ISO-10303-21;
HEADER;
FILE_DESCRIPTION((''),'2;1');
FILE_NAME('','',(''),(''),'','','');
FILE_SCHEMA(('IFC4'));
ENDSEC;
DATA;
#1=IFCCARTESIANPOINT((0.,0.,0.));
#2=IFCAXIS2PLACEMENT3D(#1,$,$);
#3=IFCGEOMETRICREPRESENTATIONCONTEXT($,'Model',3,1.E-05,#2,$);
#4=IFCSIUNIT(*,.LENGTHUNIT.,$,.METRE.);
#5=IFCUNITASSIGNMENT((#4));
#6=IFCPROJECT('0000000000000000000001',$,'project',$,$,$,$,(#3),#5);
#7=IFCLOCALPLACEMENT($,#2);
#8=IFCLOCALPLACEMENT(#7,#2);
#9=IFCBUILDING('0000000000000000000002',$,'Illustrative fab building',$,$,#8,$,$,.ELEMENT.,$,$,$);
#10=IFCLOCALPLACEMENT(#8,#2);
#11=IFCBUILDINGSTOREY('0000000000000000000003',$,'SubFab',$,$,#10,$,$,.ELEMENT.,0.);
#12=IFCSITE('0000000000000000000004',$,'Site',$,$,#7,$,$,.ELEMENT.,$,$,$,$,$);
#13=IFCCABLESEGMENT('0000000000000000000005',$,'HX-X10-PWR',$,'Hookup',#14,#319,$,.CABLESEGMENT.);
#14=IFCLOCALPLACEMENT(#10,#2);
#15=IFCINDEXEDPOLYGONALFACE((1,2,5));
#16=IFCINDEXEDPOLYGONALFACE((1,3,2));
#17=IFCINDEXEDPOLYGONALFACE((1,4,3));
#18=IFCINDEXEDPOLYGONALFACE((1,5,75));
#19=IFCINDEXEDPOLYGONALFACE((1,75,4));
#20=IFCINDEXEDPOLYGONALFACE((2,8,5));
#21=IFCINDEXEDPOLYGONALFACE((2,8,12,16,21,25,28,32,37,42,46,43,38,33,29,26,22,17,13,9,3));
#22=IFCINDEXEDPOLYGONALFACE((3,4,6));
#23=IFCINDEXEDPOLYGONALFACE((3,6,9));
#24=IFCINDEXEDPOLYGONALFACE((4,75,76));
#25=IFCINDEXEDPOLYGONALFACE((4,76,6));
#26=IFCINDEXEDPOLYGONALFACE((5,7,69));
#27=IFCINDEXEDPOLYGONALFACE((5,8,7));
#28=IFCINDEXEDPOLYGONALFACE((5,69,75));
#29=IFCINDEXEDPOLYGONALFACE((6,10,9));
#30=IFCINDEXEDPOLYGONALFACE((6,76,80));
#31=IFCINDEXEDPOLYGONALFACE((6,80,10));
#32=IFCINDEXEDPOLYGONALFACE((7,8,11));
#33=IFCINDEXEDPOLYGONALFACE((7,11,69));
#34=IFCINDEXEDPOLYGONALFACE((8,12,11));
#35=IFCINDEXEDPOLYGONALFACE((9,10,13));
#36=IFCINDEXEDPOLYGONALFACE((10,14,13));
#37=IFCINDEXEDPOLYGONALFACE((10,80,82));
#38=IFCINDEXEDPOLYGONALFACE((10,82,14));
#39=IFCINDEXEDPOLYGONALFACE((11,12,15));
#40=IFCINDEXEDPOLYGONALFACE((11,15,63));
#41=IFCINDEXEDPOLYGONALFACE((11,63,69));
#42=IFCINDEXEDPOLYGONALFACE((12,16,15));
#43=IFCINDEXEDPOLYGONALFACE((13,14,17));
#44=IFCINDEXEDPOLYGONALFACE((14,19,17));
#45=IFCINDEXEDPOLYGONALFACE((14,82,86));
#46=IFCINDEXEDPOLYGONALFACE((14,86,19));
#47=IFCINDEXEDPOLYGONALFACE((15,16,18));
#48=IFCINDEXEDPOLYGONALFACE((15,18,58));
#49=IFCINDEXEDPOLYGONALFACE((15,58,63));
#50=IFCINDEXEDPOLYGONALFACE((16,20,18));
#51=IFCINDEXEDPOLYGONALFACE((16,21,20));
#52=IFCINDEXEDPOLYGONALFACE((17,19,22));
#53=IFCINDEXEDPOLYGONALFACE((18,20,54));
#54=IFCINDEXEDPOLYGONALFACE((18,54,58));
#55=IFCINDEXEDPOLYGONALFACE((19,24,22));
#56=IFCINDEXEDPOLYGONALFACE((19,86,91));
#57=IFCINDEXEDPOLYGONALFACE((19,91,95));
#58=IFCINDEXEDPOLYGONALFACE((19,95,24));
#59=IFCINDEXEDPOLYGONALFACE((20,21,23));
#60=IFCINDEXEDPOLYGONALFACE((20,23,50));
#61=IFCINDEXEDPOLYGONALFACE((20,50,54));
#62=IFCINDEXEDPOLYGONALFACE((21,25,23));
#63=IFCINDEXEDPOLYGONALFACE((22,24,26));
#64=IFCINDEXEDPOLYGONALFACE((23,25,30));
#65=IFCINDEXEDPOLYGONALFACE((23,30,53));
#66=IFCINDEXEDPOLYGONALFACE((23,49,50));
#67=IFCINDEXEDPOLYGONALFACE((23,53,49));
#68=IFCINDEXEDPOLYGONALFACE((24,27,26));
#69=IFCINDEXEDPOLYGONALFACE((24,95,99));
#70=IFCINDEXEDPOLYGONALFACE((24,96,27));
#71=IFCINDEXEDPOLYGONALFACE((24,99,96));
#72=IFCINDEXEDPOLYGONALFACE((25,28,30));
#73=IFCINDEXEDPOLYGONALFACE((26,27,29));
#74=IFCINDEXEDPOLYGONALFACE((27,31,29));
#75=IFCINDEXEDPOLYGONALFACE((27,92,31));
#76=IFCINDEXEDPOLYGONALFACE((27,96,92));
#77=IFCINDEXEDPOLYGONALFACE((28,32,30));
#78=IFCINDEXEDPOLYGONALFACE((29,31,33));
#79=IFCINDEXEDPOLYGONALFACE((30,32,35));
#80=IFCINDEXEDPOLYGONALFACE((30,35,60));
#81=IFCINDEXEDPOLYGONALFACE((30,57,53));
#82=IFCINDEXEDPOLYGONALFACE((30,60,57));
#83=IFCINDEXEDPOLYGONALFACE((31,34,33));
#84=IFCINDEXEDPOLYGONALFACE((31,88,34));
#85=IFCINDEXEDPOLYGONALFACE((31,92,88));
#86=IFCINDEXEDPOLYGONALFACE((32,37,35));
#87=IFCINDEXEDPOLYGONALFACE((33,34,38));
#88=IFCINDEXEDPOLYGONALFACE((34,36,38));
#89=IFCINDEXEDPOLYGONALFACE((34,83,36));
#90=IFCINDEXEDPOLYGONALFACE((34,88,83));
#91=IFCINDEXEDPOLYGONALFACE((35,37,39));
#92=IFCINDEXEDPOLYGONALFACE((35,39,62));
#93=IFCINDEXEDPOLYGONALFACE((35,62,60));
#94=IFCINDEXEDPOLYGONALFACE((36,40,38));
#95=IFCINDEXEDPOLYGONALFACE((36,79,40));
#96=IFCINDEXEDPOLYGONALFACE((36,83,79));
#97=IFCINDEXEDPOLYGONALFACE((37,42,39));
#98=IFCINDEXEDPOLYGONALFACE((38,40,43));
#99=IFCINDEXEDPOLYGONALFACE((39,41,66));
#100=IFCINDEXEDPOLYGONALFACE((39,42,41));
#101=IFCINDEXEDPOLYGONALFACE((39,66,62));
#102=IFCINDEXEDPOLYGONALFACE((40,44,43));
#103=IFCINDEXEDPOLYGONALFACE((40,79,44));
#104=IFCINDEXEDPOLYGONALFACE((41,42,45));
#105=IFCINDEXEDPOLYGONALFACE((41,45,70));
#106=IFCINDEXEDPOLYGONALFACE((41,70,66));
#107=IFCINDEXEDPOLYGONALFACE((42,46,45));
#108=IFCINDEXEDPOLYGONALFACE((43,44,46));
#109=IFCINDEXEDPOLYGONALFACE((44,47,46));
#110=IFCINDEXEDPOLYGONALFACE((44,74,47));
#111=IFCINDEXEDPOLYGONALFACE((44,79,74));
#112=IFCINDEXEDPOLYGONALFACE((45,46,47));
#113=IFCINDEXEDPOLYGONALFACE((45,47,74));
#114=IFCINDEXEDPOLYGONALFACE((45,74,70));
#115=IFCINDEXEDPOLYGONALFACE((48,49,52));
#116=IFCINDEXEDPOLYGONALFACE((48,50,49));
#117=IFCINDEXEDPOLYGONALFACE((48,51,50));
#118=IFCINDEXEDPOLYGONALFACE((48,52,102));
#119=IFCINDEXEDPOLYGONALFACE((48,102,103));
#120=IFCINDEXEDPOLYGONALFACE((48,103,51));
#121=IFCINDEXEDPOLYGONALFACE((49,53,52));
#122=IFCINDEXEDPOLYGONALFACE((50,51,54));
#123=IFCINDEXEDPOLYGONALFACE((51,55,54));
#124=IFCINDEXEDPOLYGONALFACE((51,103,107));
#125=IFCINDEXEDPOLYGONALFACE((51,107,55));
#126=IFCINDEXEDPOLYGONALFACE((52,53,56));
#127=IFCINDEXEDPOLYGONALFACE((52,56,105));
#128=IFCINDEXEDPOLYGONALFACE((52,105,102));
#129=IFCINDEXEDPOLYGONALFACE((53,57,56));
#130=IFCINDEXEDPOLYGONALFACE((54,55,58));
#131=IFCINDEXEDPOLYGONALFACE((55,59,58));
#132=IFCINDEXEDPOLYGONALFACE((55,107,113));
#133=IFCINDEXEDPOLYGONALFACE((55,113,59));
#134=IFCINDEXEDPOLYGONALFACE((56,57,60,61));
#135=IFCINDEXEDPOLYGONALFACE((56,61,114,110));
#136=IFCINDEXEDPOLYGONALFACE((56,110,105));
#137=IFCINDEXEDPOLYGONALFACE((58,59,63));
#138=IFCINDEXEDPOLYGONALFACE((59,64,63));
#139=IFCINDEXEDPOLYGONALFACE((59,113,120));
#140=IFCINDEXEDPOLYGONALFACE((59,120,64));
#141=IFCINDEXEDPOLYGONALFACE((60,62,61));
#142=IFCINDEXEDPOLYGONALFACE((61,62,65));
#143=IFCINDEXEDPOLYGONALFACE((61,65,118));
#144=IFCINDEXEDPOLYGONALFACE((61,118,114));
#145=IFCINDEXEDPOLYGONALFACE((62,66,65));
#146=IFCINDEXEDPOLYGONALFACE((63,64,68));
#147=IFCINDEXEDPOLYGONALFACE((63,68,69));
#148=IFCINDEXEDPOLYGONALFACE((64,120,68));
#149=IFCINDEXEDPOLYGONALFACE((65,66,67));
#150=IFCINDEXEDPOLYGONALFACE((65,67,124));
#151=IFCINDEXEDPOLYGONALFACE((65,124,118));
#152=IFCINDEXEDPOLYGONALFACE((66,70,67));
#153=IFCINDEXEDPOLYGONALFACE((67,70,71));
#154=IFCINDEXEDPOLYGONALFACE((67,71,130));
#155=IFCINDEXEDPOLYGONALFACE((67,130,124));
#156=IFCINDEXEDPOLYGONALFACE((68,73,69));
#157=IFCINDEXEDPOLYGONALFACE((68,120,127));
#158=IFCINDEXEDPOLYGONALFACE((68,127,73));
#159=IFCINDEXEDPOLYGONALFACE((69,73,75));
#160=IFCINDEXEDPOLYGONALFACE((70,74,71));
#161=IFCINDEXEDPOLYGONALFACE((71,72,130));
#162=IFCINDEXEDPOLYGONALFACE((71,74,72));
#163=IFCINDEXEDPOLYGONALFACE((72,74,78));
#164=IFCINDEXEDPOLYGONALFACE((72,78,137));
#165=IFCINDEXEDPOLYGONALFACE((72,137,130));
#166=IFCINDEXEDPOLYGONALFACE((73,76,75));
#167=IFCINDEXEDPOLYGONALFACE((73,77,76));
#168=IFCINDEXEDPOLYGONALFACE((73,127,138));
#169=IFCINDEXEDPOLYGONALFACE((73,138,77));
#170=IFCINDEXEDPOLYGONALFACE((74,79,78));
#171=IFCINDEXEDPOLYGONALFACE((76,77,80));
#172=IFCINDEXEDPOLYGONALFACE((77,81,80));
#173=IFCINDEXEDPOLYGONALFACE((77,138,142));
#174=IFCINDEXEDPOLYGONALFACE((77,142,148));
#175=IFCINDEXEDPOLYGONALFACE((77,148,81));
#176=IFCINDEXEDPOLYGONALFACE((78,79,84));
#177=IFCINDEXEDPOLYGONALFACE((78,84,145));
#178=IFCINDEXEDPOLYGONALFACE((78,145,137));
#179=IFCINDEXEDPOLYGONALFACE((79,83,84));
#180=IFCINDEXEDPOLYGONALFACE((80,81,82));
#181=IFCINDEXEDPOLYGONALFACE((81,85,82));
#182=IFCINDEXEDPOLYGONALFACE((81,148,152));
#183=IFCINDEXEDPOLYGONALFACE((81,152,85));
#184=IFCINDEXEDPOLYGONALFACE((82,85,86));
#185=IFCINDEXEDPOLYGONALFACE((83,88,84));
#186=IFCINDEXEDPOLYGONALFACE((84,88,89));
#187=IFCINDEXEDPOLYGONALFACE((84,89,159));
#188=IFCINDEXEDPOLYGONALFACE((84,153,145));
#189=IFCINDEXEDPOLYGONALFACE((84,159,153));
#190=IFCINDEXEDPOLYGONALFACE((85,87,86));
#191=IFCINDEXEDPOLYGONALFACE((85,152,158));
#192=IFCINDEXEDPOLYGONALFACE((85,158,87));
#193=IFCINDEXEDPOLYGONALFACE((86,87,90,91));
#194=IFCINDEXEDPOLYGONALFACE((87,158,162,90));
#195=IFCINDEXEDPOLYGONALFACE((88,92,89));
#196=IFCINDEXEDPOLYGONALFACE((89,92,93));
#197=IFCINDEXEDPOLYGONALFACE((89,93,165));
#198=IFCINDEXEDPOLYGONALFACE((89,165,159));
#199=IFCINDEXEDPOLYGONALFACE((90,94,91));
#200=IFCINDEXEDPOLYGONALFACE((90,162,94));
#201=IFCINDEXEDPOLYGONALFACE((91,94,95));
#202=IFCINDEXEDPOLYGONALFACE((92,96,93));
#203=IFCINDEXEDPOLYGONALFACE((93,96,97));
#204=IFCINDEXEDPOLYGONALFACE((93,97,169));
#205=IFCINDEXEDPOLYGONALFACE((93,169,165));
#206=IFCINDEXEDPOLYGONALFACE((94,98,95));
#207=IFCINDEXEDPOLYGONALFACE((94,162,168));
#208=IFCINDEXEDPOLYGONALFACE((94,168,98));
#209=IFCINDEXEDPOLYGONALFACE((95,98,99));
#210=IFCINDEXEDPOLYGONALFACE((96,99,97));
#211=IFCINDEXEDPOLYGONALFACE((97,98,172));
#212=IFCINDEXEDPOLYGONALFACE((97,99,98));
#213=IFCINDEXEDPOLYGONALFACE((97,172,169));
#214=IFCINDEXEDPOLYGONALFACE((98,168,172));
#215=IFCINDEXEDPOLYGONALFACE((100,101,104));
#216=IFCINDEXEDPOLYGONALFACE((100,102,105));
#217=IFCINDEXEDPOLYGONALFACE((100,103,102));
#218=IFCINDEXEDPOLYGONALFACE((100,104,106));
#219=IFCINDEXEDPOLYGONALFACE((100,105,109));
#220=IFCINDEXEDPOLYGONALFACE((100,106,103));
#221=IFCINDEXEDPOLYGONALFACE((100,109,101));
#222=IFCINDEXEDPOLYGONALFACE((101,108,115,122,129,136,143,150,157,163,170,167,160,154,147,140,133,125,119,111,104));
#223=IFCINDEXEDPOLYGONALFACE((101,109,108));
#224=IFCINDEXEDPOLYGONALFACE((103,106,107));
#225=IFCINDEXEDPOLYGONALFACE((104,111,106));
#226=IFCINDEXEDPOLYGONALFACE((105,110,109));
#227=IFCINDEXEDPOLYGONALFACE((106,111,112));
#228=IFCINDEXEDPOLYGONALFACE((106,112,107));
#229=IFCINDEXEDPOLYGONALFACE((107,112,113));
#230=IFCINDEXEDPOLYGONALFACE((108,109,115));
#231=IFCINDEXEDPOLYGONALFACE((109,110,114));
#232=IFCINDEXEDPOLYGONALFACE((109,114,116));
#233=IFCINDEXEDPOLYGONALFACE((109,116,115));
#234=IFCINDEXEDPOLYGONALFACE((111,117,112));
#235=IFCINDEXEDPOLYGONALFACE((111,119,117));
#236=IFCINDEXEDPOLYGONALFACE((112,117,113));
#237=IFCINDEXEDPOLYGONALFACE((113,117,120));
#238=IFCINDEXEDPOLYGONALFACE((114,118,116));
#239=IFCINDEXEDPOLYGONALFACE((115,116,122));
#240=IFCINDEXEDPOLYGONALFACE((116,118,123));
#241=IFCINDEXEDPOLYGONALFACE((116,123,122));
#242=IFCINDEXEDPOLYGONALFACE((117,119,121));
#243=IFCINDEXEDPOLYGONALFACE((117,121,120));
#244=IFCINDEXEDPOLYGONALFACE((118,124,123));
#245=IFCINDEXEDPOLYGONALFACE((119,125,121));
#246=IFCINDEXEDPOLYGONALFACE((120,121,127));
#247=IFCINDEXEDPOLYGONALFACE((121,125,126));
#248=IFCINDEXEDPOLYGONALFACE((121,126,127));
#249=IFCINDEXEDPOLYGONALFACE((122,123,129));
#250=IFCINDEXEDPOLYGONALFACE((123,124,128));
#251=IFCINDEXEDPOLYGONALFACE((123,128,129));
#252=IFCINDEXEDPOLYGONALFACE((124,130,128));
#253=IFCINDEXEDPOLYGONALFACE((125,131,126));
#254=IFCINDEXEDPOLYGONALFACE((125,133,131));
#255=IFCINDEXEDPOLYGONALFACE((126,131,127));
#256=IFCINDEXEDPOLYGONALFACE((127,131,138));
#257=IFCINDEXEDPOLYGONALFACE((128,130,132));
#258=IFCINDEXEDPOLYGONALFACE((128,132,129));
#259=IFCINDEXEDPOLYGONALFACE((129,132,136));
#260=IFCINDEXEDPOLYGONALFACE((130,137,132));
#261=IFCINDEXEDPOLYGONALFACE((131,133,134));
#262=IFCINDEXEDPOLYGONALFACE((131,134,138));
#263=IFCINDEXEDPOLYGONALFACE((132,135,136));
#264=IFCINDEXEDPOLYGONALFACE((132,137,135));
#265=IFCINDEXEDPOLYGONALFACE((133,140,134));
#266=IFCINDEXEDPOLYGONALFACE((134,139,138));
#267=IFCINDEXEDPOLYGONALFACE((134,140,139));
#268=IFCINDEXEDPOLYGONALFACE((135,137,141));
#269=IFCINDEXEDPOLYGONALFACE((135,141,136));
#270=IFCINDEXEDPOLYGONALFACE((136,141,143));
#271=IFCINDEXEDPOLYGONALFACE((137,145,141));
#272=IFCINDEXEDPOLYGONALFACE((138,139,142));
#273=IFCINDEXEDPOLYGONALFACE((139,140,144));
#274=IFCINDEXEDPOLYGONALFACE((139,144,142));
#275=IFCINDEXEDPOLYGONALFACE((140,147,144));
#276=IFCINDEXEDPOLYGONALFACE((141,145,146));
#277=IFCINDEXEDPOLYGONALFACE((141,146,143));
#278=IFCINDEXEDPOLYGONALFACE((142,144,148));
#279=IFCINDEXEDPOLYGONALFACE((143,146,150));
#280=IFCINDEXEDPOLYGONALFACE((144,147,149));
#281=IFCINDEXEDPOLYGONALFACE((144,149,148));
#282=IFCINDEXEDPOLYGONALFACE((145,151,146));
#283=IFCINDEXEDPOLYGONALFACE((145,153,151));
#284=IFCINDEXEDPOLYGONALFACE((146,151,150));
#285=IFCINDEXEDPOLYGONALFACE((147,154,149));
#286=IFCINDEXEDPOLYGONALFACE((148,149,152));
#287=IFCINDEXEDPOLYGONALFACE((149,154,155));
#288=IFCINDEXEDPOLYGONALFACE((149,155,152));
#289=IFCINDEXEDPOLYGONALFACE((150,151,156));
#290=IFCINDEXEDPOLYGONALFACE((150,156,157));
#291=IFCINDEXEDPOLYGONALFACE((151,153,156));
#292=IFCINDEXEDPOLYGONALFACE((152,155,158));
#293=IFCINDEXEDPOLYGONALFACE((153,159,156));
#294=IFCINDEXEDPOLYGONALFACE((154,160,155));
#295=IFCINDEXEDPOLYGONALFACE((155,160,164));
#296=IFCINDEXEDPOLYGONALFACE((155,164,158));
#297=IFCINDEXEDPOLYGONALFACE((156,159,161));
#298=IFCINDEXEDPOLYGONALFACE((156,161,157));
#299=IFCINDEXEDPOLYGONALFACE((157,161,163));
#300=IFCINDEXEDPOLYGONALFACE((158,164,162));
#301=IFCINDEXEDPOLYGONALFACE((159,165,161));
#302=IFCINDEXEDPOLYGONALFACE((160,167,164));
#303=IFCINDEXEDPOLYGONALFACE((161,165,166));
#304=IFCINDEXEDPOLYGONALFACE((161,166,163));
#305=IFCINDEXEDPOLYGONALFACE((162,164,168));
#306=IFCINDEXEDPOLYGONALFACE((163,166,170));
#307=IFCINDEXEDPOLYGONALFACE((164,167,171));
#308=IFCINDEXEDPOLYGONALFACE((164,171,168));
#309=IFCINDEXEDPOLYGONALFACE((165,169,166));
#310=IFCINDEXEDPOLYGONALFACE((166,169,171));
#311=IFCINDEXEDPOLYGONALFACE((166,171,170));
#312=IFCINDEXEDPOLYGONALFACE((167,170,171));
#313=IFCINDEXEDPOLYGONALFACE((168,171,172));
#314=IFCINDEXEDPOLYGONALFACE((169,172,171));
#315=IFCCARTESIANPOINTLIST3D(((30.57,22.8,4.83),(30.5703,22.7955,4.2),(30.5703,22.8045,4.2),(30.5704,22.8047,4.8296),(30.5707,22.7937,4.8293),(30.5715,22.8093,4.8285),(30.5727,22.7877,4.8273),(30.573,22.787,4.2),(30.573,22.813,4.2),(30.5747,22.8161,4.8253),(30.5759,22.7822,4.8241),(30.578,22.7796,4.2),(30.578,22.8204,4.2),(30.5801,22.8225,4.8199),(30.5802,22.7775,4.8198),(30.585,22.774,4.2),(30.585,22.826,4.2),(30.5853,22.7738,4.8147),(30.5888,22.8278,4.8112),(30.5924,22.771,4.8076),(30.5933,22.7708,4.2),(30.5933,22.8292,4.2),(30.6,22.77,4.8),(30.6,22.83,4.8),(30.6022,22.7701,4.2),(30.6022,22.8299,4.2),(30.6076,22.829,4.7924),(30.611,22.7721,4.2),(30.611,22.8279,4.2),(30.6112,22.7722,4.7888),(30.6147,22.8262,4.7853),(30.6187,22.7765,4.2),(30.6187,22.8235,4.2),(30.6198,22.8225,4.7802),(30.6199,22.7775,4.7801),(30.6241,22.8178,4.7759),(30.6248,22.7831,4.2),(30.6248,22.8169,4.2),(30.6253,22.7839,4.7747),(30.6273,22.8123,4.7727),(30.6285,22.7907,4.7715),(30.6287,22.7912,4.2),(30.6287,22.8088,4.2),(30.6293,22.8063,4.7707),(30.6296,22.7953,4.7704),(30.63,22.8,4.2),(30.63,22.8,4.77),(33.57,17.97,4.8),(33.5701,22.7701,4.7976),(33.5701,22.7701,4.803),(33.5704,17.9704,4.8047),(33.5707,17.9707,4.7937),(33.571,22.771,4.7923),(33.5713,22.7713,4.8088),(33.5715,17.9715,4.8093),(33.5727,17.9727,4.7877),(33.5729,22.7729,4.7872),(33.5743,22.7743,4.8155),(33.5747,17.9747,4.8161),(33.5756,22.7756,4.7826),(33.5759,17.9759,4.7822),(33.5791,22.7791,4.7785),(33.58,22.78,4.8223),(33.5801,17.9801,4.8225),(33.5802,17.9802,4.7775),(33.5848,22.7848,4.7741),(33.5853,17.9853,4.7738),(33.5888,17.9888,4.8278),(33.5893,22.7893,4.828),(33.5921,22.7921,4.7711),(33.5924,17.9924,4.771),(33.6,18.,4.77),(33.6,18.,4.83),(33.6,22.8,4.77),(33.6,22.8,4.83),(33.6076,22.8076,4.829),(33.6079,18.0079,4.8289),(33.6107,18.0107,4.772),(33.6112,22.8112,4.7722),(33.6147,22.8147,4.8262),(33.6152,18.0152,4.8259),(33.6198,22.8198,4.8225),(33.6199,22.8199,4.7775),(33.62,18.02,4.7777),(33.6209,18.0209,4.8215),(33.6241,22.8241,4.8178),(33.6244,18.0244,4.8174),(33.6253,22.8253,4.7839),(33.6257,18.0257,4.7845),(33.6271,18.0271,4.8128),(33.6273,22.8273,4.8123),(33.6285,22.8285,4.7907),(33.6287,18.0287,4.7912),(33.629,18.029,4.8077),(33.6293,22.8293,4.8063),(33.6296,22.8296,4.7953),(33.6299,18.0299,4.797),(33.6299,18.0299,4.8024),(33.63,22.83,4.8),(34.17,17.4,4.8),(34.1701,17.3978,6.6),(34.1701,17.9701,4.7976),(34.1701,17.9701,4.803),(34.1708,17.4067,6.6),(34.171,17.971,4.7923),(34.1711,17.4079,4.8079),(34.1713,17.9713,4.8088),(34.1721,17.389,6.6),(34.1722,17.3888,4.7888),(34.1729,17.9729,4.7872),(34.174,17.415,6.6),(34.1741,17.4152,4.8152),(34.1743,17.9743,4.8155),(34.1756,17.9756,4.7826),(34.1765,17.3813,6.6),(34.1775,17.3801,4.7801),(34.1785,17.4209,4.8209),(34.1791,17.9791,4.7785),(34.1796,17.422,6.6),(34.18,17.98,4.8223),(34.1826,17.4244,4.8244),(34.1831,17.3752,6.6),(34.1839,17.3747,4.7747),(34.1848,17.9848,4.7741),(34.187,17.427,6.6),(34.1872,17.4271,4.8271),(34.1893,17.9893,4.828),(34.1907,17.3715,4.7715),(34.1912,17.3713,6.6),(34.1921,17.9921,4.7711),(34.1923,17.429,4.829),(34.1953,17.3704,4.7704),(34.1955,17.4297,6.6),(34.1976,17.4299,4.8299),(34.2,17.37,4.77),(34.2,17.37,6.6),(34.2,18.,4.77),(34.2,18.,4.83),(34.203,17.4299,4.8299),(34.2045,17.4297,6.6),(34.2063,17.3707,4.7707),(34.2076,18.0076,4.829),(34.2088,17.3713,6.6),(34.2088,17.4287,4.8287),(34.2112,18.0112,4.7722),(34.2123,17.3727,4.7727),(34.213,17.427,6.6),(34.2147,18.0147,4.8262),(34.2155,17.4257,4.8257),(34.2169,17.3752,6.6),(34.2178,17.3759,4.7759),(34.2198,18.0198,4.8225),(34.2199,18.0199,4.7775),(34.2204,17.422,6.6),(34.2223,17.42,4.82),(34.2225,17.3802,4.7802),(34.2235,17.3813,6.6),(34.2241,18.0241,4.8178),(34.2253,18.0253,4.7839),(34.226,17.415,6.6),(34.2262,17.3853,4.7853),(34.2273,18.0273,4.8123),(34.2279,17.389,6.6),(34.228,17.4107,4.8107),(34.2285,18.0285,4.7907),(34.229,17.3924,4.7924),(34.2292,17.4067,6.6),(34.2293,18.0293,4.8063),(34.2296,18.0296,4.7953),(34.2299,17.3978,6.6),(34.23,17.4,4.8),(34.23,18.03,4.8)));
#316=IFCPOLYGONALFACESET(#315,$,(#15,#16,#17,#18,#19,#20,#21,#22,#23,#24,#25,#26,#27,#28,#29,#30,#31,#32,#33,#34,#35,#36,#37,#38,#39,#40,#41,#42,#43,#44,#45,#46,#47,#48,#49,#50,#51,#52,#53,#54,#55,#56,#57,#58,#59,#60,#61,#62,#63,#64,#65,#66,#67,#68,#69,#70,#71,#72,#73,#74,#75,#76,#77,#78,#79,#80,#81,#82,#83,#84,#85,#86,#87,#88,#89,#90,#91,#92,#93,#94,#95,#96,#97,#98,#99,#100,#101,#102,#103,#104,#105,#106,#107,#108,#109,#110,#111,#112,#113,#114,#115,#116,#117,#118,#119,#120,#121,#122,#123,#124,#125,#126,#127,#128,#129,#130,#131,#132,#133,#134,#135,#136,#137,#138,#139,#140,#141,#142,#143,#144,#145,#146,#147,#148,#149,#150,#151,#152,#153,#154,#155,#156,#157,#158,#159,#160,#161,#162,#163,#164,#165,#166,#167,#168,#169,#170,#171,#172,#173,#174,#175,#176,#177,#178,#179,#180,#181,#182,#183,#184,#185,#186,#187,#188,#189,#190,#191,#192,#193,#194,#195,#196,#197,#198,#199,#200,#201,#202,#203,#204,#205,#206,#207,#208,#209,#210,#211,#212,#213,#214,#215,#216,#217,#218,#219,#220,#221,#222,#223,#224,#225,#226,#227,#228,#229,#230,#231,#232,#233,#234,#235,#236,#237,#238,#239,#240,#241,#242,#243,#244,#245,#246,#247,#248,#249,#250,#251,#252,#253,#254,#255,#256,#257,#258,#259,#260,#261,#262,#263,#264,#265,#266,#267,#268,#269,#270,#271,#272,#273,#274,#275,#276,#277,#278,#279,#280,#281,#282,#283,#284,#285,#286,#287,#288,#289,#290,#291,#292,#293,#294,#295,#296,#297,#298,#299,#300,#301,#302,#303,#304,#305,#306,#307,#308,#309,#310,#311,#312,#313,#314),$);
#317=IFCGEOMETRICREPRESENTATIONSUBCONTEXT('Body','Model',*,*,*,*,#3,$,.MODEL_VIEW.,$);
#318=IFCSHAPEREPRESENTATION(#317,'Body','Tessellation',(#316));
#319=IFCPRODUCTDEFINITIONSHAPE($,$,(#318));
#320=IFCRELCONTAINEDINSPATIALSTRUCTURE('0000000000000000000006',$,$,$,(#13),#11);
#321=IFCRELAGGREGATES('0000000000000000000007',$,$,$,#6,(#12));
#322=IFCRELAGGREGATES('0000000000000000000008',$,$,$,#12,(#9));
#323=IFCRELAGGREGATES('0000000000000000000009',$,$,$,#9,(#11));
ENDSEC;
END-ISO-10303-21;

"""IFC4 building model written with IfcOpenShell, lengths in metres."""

from ifc_helpers import new_model, entity, si_unit, origin, place, context, subcontext, project, spatial, element, save


model = new_model("IFC4")

# Units and contexts
model_context = context("Model", 3, precision=1e-05, world=origin())
body_context = subcontext(model_context, "Body", "Model", "MODEL_VIEW")
ifc_project = project(units=[si_unit("LENGTHUNIT", "METRE")], contexts=[model_context])

# Site, building, storey
site_placement = place(None, origin())
site = spatial("IfcSite", under=ifc_project, at=site_placement, Name="Site", CompositionType="ELEMENT")
building_placement = place(site_placement, origin())
building = spatial("IfcBuilding", under=site, at=building_placement, Name="Illustrative fab building", CompositionType="ELEMENT")
storey_placement = place(building_placement, origin())
storey = spatial("IfcBuildingStorey", under=building, at=storey_placement, Name="SubFab", CompositionType="ELEMENT", Elevation=0.0)

# Cable segment
cable_segment_1_placement = place(storey_placement, origin())
element("IfcCableSegment", 1, at=cable_segment_1_placement, inside=storey, Name="HX-X10-PWR", ObjectType="Hookup", PredefinedType="CABLESEGMENT", context=body_context, shape_type="AdvancedSweptSolid", body=[
    entity("IfcSweptDiskSolid", entity("IfcPolyline", [entity("IfcCartesianPoint", [30.6, 22.8, 4.2]), entity("IfcCartesianPoint", [30.6, 22.8, 4.8]), entity("IfcCartesianPoint", [33.6, 22.8, 4.8]), entity("IfcCartesianPoint", [33.6, 18.0, 4.8]), entity("IfcCartesianPoint", [34.2, 18.0, 4.8]), entity("IfcCartesianPoint", [34.2, 17.4, 4.8]), entity("IfcCartesianPoint", [34.2, 17.4, 6.6])]), 0.03),
])

save(model, "model.ifc")
